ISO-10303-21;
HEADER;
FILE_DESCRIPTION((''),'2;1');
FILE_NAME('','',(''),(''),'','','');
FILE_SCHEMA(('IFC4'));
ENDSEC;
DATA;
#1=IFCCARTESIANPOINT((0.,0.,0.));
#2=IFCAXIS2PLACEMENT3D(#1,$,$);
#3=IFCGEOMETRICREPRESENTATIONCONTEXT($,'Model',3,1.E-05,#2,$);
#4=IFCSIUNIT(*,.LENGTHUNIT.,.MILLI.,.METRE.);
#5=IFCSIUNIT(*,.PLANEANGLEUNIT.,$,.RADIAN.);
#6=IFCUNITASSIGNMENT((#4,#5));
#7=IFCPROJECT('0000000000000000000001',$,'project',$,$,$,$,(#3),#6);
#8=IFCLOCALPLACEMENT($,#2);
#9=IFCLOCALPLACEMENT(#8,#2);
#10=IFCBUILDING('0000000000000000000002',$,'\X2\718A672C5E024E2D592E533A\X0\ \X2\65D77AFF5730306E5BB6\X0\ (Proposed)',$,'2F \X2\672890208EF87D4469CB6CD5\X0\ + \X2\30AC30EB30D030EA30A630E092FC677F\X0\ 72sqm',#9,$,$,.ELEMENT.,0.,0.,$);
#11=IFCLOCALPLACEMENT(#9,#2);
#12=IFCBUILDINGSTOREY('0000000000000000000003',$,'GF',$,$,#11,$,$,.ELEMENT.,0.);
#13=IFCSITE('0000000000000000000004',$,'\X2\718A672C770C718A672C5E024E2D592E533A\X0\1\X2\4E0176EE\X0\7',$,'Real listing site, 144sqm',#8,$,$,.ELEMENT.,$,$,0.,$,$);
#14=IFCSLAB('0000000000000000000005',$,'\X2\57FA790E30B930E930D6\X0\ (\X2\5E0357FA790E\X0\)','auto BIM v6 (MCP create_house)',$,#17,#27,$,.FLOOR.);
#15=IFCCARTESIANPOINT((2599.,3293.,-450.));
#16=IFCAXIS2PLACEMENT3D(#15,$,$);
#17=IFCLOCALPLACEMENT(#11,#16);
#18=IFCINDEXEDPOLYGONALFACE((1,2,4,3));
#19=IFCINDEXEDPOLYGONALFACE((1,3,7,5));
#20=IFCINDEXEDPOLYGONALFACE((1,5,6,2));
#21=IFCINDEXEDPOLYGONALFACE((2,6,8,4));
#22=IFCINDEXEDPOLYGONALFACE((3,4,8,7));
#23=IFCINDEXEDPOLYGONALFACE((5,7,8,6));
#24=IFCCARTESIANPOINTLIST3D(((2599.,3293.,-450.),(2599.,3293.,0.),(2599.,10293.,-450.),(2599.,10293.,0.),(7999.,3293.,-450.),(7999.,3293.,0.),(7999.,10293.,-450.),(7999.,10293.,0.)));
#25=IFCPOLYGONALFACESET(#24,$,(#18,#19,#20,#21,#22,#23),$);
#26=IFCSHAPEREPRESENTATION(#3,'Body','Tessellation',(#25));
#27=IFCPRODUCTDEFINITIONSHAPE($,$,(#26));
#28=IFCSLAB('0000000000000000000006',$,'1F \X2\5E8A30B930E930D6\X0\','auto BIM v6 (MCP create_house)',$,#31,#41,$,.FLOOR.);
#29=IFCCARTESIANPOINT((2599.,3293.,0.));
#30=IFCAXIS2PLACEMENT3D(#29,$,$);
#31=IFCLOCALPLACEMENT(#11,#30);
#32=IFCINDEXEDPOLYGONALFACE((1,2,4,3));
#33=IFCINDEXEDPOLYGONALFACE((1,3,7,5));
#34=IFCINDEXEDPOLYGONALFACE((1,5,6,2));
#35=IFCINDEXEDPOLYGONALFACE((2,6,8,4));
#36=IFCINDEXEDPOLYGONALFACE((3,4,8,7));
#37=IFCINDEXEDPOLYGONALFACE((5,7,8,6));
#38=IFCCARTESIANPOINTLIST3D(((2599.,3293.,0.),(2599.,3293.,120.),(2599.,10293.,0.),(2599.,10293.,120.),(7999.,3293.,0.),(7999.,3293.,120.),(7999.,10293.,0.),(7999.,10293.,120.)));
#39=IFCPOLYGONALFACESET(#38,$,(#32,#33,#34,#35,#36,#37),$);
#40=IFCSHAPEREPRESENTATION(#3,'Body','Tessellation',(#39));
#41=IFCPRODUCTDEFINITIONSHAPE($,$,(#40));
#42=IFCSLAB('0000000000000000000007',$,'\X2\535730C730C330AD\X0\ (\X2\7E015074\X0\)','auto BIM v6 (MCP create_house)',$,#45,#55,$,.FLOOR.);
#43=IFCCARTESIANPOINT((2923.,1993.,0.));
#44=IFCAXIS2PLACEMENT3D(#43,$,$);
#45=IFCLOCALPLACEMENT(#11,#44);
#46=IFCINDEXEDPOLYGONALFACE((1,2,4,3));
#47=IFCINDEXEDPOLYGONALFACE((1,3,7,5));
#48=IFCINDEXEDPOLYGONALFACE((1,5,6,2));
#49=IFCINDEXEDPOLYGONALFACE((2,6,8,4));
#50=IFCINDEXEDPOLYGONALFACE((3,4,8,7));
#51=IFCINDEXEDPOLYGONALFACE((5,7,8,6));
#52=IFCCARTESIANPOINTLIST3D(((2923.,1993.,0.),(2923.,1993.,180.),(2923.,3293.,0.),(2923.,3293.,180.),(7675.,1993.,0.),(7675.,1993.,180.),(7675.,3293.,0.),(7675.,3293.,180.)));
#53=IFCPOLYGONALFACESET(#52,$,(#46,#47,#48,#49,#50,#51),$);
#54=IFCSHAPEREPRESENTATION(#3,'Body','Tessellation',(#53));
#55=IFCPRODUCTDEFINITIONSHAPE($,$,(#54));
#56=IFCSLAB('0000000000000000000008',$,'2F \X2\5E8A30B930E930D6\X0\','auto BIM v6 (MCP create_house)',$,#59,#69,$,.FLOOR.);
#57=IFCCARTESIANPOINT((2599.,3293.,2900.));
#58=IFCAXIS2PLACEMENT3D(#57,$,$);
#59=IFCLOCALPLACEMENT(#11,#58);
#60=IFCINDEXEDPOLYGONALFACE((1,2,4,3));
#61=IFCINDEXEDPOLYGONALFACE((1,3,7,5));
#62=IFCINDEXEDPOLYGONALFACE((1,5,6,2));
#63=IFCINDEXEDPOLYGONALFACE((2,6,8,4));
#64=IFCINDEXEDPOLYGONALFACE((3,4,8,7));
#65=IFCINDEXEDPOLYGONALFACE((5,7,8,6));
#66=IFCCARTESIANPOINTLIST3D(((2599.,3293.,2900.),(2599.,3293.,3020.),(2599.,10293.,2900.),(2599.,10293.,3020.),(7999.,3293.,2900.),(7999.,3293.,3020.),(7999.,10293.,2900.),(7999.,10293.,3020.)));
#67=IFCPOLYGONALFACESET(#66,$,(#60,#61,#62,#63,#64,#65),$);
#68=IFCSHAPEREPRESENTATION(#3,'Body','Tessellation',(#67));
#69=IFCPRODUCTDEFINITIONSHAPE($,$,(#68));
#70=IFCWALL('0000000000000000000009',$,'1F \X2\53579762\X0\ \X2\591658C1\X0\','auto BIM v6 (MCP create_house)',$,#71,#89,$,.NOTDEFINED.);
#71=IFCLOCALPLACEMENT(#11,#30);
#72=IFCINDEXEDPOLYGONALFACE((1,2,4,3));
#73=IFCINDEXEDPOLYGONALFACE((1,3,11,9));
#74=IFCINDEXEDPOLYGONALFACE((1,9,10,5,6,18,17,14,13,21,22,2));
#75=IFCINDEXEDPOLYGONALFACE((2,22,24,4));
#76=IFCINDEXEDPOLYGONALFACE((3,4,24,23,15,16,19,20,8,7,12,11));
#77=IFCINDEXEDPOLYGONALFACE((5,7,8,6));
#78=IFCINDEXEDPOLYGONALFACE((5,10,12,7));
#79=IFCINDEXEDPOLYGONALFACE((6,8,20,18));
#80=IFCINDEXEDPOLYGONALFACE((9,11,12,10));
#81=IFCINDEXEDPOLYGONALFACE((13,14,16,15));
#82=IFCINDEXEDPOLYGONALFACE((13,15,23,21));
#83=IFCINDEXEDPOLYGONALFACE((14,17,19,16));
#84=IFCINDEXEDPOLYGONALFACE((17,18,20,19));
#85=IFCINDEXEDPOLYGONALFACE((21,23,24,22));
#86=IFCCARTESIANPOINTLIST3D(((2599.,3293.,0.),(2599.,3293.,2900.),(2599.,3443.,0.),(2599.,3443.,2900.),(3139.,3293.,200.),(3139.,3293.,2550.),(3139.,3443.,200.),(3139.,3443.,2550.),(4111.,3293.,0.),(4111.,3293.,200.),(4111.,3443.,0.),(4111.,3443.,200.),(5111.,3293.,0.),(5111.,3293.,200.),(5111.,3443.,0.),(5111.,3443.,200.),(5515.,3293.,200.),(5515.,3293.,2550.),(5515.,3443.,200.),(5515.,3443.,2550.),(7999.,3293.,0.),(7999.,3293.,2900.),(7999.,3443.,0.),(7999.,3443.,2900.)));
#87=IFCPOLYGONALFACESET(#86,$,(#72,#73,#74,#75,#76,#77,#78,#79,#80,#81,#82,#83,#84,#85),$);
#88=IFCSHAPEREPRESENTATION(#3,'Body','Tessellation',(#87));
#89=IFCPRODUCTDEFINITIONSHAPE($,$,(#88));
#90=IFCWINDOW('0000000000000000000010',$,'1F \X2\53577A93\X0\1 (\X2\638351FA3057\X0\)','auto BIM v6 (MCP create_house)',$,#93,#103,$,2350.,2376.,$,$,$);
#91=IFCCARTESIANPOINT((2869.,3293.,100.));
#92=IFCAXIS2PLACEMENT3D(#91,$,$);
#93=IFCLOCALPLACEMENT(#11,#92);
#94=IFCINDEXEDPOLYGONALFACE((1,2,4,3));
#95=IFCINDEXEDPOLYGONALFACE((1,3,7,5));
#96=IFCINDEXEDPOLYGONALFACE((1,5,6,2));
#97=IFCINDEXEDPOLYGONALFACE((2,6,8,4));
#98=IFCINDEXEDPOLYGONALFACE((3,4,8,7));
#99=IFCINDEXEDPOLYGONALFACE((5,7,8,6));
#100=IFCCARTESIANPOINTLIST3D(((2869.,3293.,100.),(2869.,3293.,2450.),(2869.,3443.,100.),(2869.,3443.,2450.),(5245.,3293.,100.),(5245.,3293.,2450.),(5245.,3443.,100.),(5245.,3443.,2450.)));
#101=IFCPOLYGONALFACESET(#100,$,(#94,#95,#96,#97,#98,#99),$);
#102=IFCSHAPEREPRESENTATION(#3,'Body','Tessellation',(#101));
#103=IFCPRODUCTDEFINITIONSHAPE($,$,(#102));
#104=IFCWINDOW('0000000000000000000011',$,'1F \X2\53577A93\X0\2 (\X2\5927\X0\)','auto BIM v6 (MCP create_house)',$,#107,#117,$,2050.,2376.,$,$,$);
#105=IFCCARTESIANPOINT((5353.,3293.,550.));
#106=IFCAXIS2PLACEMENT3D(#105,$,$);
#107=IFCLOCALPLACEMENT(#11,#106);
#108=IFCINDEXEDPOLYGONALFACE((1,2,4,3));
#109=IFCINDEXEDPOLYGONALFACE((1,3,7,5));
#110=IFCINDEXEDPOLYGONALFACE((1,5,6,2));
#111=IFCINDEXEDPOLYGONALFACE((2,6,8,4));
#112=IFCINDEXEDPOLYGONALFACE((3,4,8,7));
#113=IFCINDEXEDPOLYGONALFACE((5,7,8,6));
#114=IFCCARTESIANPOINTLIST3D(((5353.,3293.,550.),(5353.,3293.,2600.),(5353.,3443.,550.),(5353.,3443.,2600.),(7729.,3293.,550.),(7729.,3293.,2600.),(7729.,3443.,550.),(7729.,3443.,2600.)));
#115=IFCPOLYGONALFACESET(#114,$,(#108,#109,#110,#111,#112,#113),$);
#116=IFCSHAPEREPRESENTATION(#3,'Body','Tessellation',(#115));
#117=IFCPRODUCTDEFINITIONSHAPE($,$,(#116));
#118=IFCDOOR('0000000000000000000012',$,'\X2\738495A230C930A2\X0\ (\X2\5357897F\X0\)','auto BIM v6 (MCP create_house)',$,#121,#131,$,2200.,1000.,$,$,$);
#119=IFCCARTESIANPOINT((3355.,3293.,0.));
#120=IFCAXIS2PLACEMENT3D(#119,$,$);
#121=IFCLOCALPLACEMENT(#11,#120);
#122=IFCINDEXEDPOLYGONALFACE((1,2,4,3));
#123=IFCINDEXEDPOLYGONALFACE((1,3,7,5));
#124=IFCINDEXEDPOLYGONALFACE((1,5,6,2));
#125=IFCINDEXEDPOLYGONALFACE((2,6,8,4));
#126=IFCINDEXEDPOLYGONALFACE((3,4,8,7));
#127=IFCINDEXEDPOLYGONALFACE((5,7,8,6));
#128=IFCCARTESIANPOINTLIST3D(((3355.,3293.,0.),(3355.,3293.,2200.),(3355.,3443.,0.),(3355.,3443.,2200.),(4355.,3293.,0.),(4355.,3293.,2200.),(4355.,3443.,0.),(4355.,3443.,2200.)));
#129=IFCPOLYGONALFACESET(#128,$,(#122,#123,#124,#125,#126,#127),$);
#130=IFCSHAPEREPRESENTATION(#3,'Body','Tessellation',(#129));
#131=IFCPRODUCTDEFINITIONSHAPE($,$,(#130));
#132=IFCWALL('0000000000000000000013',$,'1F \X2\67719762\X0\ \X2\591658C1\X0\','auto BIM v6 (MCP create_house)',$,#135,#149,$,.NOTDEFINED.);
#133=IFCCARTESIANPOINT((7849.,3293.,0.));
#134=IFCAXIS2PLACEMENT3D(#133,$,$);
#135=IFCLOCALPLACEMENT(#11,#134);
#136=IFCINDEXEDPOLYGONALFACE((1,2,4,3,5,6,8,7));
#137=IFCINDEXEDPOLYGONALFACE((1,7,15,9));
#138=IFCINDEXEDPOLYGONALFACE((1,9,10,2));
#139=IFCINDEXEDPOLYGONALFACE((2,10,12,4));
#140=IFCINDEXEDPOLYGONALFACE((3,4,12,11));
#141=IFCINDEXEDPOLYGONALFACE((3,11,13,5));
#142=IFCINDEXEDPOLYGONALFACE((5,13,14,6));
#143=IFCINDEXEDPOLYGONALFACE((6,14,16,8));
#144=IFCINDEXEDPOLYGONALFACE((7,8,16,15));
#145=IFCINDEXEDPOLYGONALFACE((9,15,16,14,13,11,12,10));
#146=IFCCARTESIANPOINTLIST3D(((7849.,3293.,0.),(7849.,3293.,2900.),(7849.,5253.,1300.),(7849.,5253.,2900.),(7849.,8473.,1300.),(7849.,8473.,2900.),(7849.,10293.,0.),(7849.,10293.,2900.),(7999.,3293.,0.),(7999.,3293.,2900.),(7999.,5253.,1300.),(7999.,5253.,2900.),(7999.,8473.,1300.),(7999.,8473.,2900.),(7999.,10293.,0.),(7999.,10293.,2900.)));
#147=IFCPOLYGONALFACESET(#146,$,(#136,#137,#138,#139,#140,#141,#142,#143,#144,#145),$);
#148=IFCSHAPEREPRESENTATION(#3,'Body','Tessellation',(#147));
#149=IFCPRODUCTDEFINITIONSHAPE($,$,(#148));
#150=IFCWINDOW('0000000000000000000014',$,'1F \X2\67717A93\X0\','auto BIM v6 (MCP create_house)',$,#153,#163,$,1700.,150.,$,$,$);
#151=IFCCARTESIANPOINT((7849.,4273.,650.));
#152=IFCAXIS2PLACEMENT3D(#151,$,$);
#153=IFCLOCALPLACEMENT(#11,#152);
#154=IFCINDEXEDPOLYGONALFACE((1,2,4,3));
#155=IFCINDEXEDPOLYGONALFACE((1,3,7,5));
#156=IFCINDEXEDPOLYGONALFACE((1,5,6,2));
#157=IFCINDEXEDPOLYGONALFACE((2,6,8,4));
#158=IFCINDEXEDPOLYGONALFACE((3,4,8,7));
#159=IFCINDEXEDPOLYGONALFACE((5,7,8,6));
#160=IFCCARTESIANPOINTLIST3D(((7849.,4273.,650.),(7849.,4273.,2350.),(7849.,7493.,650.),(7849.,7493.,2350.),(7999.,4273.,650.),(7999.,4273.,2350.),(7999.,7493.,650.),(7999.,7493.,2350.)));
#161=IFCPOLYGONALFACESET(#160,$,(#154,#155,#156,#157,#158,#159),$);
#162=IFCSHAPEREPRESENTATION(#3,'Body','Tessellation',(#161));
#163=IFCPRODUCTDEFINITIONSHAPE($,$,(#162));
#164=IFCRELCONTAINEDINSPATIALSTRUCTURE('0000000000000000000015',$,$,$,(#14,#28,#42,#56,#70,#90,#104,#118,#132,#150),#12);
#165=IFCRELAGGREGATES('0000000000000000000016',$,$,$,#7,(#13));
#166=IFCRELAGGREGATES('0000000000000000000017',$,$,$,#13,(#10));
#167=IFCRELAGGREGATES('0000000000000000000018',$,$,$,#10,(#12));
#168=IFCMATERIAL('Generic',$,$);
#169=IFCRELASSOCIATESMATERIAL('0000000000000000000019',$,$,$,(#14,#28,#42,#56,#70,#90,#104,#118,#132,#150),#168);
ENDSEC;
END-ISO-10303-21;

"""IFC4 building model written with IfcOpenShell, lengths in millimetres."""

from ifc_helpers import new_model, si_unit, frame, frame_2d, origin, place, context, project, spatial, rectangle, extrude, material, element, fill, save


model = new_model("IFC4")

# Units and contexts
model_context = context("Model", 3, precision=1e-05, world=origin())
ifc_project = project(units=[si_unit("LENGTHUNIT", "METRE", prefix="MILLI"), si_unit("PLANEANGLEUNIT", "RADIAN")], contexts=[model_context])

# Site, building, storey
site_placement = place(None, origin())
site = spatial("IfcSite", under=ifc_project, at=site_placement, Name="熊本県熊本市中央区1丁目7", ObjectType="Real listing site, 144sqm", CompositionType="ELEMENT", RefElevation=0.0)
building_placement = place(site_placement, origin())
building = spatial("IfcBuilding", under=site, at=building_placement, Name="熊本市中央区 旗竿地の家 (Proposed)", ObjectType="2F 木造軸組構法 + ガルバリウム鋼板 72sqm", CompositionType="ELEMENT", ElevationOfRefHeight=0.0, ElevationOfTerrain=0.0)
storey_placement = place(building_placement, origin())
storey = spatial("IfcBuildingStorey", under=building, at=storey_placement, Name="GF", CompositionType="ELEMENT", Elevation=0.0)

# Slabs
ifc_material = material(Name="Generic")
slab_1_placement = place(storey_placement, frame((2599.0, 3293.0, -450.0)))
element("IfcSlab", 1, at=slab_1_placement, inside=storey, material=ifc_material, Name="基礎スラブ (布基礎)", Description="auto BIM v6 (MCP create_house)", PredefinedType="FLOOR", context=model_context, shape_type="SweptSolid", body=[
    extrude(rectangle(XDim=5400.0, YDim=7000.0, at=frame_2d((2700.0, 3500.0))), frame((2599.0, 3293.0, -450.0)), (0.0, 0.0, 1.0), 450.0),
])
slab_2_placement = place(storey_placement, frame((2599.0, 3293.0, 0.0)))
element("IfcSlab", 2, at=slab_2_placement, inside=storey, material=ifc_material, Name="1F 床スラブ", Description="auto BIM v6 (MCP create_house)", PredefinedType="FLOOR", context=model_context, shape_type="SweptSolid", body=[
    extrude(rectangle(XDim=5400.0, YDim=7000.0, at=frame_2d((2700.0, 3500.0))), frame((2599.0, 3293.0, 0.0)), (0.0, 0.0, 1.0), 120.0),
])
slab_3_placement = place(storey_placement, frame((2923.0, 1993.0, 0.0)))
element("IfcSlab", 3, at=slab_3_placement, inside=storey, material=ifc_material, Name="南デッキ (縁側)", Description="auto BIM v6 (MCP create_house)", PredefinedType="FLOOR", context=model_context, shape_type="SweptSolid", body=[
    extrude(rectangle(XDim=4752.0, YDim=1300.0, at=frame_2d((2376.0, 650.0))), frame((2923.0, 1993.0, 0.0)), (0.0, 0.0, 1.0), 180.0),
])
slab_4_placement = place(storey_placement, frame((2599.0, 3293.0, 2900.0)))
element("IfcSlab", 4, at=slab_4_placement, inside=storey, material=ifc_material, Name="2F 床スラブ", Description="auto BIM v6 (MCP create_house)", PredefinedType="FLOOR", context=model_context, shape_type="SweptSolid", body=[
    extrude(rectangle(XDim=5400.0, YDim=7000.0, at=frame_2d((2700.0, 3500.0))), frame((2599.0, 3293.0, 2900.0)), (0.0, 0.0, 1.0), 120.0),
])

# Wall, openings, windows, door
wall_1_placement = place(storey_placement, frame((2599.0, 3293.0, 0.0)))
wall_1 = element("IfcWall", 5, at=wall_1_placement, inside=storey, material=ifc_material, Name="1F 南面 外壁", Description="auto BIM v6 (MCP create_house)", PredefinedType="NOTDEFINED", context=model_context, shape_type="SweptSolid", body=[
    extrude(rectangle(XDim=5400.0, YDim=150.0, at=frame_2d((2700.0, 75.0))), frame((2599.0, 3293.0, 0.0)), (0.0, 0.0, 1.0), 2900.0),
])
opening_1_placement = place(storey_placement, frame((2869.0, 3293.0, 100.0)))
opening_1 = element("IfcOpeningElement", 6, at=opening_1_placement, cuts=wall_1, PredefinedType="NOTDEFINED", context=model_context, shape_type="SweptSolid", body=[
    extrude(rectangle(XDim=2376.0, YDim=150.0, at=frame_2d((1188.0, 75.0))), frame((2869.0, 3293.0, 100.0)), (0.0, 0.0, 1.0), 2350.0),
])
opening_2_placement = place(storey_placement, frame((5353.0, 3293.0, 550.0)))
opening_2 = element("IfcOpeningElement", 7, at=opening_2_placement, cuts=wall_1, PredefinedType="NOTDEFINED", context=model_context, shape_type="SweptSolid", body=[
    extrude(rectangle(XDim=2376.0, YDim=150.0, at=frame_2d((1188.0, 75.0))), frame((5353.0, 3293.0, 550.0)), (0.0, 0.0, 1.0), 2050.0),
])
opening_3_placement = place(storey_placement, frame((3355.0, 3293.0, 0.0)))
opening_3 = element("IfcOpeningElement", 8, at=opening_3_placement, cuts=wall_1, PredefinedType="NOTDEFINED", context=model_context, shape_type="SweptSolid", body=[
    extrude(rectangle(XDim=1000.0, YDim=150.0, at=frame_2d((500.0, 75.0))), frame((3355.0, 3293.0, 0.0)), (0.0, 0.0, 1.0), 2200.0),
])
window_1_placement = place(storey_placement, frame((2869.0, 3293.0, 100.0)))
window_1 = element("IfcWindow", 9, at=window_1_placement, inside=storey, material=ifc_material, Name="1F 南窓1 (掃出し)", Description="auto BIM v6 (MCP create_house)", OverallHeight=2350.0, OverallWidth=2376.0, context=model_context, shape_type="SweptSolid", body=[
    extrude(rectangle(XDim=2376.0, YDim=150.0, at=frame_2d((1188.0, 75.0))), frame((2869.0, 3293.0, 100.0)), (0.0, 0.0, 1.0), 2350.0),
])
fill(opening_1, window_1)
window_2_placement = place(storey_placement, frame((5353.0, 3293.0, 550.0)))
window_2 = element("IfcWindow", 10, at=window_2_placement, inside=storey, material=ifc_material, Name="1F 南窓2 (大)", Description="auto BIM v6 (MCP create_house)", OverallHeight=2050.0, OverallWidth=2376.0, context=model_context, shape_type="SweptSolid", body=[
    extrude(rectangle(XDim=2376.0, YDim=150.0, at=frame_2d((1188.0, 75.0))), frame((5353.0, 3293.0, 550.0)), (0.0, 0.0, 1.0), 2050.0),
])
fill(opening_2, window_2)
door_placement = place(storey_placement, frame((3355.0, 3293.0, 0.0)))
door = element("IfcDoor", 11, at=door_placement, inside=storey, material=ifc_material, Name="玄関ドア (南西)", Description="auto BIM v6 (MCP create_house)", OverallHeight=2200.0, OverallWidth=1000.0, context=model_context, shape_type="SweptSolid", body=[
    extrude(rectangle(XDim=1000.0, YDim=150.0, at=frame_2d((500.0, 75.0))), frame((3355.0, 3293.0, 0.0)), (0.0, 0.0, 1.0), 2200.0),
])
fill(opening_3, door)

# Wall, opening, window
wall_2_placement = place(storey_placement, frame((7849.0, 3293.0, 0.0)))
wall_2 = element("IfcWall", 12, at=wall_2_placement, inside=storey, material=ifc_material, Name="1F 東面 外壁", Description="auto BIM v6 (MCP create_house)", PredefinedType="NOTDEFINED", context=model_context, shape_type="SweptSolid", body=[
    extrude(rectangle(XDim=150.0, YDim=7000.0, at=frame_2d((75.0, 3500.0))), frame((7849.0, 3293.0, 0.0)), (0.0, 0.0, 1.0), 2900.0),
])
opening_4_placement = place(storey_placement, frame((7849.0, 4273.0, 650.0)))
opening_4 = element("IfcOpeningElement", 13, at=opening_4_placement, cuts=wall_2, PredefinedType="NOTDEFINED", context=model_context, shape_type="SweptSolid", body=[
    extrude(rectangle(XDim=150.0, YDim=3220.0, at=frame_2d((75.0, 1610.0))), frame((7849.0, 4273.0, 650.0)), (0.0, 0.0, 1.0), 1700.0),
])
window_3_placement = place(storey_placement, frame((7849.0, 4273.0, 650.0)))
window_3 = element("IfcWindow", 14, at=window_3_placement, inside=storey, material=ifc_material, Name="1F 東窓", Description="auto BIM v6 (MCP create_house)", OverallHeight=1700.0, OverallWidth=150.0, context=model_context, shape_type="SweptSolid", body=[
    extrude(rectangle(XDim=150.0, YDim=3220.0, at=frame_2d((75.0, 1610.0))), frame((7849.0, 4273.0, 650.0)), (0.0, 0.0, 1.0), 1700.0),
])
fill(opening_4, window_3)

save(model, "model.ifc")
